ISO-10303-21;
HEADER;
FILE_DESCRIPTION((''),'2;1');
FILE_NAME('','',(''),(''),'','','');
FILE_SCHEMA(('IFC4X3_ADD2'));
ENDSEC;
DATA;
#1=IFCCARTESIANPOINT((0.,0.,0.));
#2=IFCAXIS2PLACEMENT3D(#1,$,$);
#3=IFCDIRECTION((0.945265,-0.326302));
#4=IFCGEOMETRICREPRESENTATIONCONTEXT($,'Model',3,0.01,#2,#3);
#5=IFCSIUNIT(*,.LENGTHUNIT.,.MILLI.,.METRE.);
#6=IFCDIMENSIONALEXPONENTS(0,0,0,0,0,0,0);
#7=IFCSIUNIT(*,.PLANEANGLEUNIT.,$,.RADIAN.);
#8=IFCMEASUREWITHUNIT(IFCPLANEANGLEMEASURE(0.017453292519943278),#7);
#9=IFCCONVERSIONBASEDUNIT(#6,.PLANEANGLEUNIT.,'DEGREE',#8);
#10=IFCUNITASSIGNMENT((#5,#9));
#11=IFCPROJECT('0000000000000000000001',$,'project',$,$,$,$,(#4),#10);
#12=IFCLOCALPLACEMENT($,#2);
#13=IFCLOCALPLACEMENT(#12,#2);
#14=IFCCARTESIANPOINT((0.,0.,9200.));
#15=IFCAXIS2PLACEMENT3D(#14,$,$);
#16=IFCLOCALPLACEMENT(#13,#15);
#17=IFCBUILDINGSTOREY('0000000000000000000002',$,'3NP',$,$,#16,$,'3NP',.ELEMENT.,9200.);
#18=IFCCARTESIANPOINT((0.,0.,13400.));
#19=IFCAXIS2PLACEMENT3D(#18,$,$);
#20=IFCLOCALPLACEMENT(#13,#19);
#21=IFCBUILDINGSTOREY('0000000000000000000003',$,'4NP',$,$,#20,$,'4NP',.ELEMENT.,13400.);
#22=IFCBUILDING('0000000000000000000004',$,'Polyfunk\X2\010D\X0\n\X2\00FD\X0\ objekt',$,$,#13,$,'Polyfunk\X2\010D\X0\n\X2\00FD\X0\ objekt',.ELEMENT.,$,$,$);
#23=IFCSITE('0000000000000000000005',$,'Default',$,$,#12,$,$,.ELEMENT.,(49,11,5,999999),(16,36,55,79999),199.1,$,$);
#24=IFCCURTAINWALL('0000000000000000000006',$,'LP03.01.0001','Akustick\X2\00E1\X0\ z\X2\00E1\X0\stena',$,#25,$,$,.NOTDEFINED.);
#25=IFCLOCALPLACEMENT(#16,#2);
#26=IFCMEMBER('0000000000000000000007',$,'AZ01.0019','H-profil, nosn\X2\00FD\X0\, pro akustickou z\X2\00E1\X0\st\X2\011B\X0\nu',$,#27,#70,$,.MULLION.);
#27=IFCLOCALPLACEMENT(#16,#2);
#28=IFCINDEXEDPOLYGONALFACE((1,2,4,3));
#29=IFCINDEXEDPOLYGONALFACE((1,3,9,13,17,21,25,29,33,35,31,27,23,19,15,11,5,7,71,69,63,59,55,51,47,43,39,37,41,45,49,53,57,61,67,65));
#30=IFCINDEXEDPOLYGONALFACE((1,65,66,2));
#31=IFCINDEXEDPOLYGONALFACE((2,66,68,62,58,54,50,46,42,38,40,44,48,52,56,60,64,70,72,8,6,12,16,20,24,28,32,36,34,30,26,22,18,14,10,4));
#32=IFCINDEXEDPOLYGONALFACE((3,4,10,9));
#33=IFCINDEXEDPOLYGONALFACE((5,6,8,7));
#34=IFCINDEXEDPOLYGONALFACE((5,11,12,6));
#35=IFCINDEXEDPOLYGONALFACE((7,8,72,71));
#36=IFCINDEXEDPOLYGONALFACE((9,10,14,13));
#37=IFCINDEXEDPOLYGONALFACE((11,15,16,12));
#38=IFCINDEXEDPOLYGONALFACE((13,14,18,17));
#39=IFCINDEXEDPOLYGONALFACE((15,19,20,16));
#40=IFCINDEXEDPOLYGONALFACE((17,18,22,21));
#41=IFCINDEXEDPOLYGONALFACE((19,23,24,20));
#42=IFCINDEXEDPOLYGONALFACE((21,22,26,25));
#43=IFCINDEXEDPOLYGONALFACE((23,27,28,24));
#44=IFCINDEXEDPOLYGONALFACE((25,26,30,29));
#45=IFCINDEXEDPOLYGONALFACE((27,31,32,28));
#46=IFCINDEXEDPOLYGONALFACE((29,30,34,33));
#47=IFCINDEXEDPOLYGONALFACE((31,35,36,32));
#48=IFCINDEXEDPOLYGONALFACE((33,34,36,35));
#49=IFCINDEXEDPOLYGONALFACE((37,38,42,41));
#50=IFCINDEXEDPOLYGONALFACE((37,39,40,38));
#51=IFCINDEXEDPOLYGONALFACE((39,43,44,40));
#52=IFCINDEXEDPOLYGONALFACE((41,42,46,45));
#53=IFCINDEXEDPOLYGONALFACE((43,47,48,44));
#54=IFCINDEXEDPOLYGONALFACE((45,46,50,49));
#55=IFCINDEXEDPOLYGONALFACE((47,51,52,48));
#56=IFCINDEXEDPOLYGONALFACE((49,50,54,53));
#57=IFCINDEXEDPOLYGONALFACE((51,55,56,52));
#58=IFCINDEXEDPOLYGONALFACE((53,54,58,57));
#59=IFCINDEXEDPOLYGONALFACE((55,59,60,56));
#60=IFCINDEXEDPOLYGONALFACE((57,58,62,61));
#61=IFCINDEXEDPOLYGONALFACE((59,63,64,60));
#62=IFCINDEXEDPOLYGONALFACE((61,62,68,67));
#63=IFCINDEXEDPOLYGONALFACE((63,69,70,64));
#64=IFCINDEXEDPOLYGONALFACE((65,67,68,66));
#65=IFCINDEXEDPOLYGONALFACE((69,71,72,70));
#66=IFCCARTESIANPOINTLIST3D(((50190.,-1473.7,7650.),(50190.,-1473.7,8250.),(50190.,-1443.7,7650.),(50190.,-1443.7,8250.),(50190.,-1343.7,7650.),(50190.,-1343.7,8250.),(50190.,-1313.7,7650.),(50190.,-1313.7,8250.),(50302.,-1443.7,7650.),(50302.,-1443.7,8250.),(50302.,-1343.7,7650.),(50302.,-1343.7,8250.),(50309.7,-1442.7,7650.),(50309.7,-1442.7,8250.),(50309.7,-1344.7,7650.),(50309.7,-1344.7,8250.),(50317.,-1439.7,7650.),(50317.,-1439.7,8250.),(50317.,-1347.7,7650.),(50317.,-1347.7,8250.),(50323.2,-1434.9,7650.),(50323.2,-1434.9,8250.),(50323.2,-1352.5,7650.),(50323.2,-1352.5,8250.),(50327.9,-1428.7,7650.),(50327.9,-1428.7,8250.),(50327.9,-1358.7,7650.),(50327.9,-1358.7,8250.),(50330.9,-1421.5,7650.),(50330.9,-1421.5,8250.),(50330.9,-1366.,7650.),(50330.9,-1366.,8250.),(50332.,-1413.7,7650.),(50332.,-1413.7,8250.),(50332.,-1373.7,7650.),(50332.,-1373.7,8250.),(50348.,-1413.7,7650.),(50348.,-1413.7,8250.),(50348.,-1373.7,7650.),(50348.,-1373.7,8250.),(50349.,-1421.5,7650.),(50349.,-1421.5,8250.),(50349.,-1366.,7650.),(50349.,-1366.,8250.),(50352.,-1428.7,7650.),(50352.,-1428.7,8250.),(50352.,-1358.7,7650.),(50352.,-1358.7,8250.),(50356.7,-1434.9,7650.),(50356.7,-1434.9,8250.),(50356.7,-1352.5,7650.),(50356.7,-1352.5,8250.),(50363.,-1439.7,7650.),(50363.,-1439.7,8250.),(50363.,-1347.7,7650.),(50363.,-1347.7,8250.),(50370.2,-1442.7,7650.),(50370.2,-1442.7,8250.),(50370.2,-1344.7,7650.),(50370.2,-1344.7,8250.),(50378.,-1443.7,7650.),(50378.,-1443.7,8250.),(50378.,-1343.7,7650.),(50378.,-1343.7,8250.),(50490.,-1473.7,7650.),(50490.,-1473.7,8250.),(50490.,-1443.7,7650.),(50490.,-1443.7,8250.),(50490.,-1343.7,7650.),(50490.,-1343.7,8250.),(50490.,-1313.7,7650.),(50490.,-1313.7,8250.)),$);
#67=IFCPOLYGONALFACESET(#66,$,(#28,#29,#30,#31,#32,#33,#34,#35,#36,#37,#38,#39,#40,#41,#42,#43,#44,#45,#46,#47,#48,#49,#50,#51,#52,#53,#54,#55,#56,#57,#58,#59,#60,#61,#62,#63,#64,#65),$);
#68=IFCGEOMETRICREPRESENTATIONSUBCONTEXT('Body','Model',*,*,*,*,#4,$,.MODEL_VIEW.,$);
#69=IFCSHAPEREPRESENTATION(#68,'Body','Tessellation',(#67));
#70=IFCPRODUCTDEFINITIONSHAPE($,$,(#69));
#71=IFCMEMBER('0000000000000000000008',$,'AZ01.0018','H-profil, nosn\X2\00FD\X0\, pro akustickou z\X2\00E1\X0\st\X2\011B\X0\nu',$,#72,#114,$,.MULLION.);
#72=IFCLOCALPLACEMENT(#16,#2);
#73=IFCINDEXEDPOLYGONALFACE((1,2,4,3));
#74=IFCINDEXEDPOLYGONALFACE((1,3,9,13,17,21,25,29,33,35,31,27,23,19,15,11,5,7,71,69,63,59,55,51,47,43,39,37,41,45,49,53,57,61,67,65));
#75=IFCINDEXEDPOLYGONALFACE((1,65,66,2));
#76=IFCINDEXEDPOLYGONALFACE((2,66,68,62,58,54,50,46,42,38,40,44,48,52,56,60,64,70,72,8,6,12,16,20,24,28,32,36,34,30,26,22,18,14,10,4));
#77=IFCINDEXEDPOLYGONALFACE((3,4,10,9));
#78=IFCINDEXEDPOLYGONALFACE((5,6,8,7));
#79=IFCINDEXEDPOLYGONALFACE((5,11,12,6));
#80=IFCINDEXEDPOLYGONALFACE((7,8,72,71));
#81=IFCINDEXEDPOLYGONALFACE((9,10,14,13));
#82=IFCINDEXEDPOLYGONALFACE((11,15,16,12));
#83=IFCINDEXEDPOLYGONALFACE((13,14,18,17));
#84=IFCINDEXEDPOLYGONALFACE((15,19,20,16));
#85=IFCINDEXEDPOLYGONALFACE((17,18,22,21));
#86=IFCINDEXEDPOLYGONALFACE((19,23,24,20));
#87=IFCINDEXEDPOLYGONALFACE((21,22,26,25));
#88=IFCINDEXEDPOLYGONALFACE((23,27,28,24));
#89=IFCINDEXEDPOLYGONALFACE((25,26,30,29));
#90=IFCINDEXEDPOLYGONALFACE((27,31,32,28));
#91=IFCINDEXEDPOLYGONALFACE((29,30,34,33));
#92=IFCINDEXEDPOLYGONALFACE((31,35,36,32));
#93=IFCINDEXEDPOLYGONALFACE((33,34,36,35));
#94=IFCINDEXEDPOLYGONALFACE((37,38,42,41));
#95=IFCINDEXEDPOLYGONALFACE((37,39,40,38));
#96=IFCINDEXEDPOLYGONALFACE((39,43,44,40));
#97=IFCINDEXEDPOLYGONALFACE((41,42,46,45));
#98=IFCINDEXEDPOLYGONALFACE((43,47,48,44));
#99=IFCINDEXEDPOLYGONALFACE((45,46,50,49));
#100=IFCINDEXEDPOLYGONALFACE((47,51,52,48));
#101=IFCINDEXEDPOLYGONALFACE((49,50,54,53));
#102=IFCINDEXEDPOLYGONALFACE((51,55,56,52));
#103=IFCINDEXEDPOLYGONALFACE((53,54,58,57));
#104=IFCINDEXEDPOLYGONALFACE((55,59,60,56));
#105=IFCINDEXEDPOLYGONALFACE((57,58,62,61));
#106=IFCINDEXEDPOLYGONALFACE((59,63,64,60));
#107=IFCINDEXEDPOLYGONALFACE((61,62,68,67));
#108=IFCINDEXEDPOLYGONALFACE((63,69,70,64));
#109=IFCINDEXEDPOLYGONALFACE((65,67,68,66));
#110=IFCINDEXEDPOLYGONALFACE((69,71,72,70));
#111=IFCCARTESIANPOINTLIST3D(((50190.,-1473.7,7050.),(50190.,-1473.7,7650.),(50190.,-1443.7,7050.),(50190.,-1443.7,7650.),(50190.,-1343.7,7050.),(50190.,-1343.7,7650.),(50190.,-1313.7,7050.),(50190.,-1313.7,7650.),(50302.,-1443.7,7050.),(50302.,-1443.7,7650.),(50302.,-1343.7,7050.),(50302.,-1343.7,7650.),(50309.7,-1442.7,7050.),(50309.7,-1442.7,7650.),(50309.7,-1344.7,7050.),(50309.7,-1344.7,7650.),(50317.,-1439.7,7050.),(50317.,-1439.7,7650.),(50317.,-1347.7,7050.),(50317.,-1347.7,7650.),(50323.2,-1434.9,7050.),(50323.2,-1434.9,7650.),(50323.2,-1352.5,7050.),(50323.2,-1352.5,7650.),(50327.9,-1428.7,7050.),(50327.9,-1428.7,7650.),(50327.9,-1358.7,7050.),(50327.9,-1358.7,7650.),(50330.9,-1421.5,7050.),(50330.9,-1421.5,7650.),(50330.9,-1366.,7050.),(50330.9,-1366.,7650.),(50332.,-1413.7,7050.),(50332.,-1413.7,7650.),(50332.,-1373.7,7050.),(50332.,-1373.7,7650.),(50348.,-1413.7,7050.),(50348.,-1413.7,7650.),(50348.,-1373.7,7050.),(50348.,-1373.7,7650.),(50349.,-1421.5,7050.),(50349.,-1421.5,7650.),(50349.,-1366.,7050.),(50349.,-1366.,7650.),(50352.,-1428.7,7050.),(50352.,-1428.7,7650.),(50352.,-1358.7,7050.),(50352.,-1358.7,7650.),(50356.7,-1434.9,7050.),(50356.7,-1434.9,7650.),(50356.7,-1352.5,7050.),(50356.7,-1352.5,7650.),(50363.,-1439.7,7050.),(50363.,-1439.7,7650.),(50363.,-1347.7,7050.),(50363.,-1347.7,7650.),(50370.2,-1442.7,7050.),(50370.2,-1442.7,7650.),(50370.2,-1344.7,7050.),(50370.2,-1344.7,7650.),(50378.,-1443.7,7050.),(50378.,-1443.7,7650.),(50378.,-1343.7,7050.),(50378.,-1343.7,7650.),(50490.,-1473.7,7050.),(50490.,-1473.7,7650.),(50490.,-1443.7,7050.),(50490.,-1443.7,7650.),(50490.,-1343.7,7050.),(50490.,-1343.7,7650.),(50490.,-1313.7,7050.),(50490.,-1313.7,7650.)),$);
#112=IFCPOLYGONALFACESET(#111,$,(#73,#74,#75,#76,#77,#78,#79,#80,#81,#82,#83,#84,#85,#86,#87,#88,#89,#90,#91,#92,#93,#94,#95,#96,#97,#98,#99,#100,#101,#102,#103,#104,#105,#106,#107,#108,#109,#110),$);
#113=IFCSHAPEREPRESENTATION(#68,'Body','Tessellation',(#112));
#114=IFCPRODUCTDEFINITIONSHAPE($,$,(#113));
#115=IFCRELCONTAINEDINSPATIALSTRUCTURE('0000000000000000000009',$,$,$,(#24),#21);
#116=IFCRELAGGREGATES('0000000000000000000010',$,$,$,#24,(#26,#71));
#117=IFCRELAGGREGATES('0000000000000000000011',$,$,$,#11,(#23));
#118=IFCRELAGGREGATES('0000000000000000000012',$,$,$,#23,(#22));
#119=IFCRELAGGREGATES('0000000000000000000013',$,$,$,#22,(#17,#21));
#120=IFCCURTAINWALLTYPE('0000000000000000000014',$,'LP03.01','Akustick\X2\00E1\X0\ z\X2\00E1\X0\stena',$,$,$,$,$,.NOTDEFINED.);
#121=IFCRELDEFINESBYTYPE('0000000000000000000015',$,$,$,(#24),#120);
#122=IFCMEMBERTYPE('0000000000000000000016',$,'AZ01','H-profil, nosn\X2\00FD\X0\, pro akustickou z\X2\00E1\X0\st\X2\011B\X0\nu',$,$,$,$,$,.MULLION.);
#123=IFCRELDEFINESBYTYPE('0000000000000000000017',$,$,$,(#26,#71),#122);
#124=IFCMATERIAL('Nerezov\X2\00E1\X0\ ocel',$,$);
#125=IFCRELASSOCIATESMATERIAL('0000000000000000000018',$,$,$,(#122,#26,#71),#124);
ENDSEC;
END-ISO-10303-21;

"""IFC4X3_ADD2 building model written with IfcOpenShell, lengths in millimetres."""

from ifc_helpers import new_model, entity, si_unit, converted_unit, direction, frame, frame_2d, origin, place, context, subcontext, project, spatial, polyline, circle_curve, parameter, trimmed, segment, composite_curve, outline, extrude, source, transform, mapped, material, material_profile, profile_set, profile_usage, type_object, element, aggregate, save


model = new_model("IFC4X3_ADD2")

# Units and contexts
model_context = context("Model", 3, precision=0.01, world=origin(), true_north=direction((0.945265, -0.326302)))
body_context = subcontext(model_context, "Body", "Model", "MODEL_VIEW")
ifc_project = project(units=[si_unit("LENGTHUNIT", "METRE", prefix="MILLI"), converted_unit("PLANEANGLEUNIT", "DEGREE", entity("IfcPlaneAngleMeasure", 0.017453292519943278), si_unit("PLANEANGLEUNIT", "RADIAN"), dimensions=[0, 0, 0, 0, 0, 0, 0])], contexts=[model_context])

# Site, building, storey
site_placement = place(None, origin())
site = spatial("IfcSite", under=ifc_project, at=site_placement, Name="Default", CompositionType="ELEMENT", RefLatitude=(49, 11, 5, 999999), RefLongitude=(16, 36, 55, 79999), RefElevation=199.1)
building_placement = place(site_placement, origin())
building = spatial("IfcBuilding", under=site, at=building_placement, Name="Polyfunkčný objekt", LongName="Polyfunkčný objekt", CompositionType="ELEMENT")
storey_1_placement = place(building_placement, frame((0.0, 0.0, 9200.0)))
storey_1 = spatial("IfcBuildingStorey", under=building, at=storey_1_placement, Name="3NP", LongName="3NP", CompositionType="ELEMENT", Elevation=9200.0)

# Shared definitions
storey_2_placement = place(building_placement, frame((0.0, 0.0, 13400.0)))
storey_2 = spatial("IfcBuildingStorey", under=building, at=storey_2_placement, Name="4NP", LongName="4NP", CompositionType="ELEMENT", Elevation=13400.0)

# Curtain wall, members
curtain_wall_type_1 = type_object("IfcCurtainWallType", Name="LP03.01", Description="Akustická zástena", PredefinedType="NOTDEFINED")
curtain_wall_1_placement = place(storey_2_placement, frame((0.0, 0.0, -13400.0)))
curtain_wall_1 = element("IfcCurtainWall", 1, at=curtain_wall_1_placement, inside=storey_2, type_object=curtain_wall_type_1, Name="LP03.01.0001", Description="Akustická zástena", PredefinedType="NOTDEFINED")
ifc_material_1 = material(Name="Nerezová ocel")
ifc_material_profile_1 = material_profile(ifc_material_1, outline(composite_curve([segment(polyline([(50.0, -150.0), (80.0, -150.0)]), True, "CONTINUOUS"), segment(polyline([(80.0, -150.0), (80.0, 150.0)]), True, "CONTINUOUS"), segment(polyline([(80.0, 150.0), (50.0, 150.0)]), True, "CONTINUOUS"), segment(polyline([(50.0, 150.0), (50.0, 38.0)]), True, "CONTINUOUS"), segment(trimmed(circle_curve(frame_2d((20.0, 38.0), x_axis=(0.0, 1.0)), 30.0), [parameter(180.0)], [parameter(270.0)], True, "PARAMETER"), False, "CONTINUOUS"), segment(polyline([(20.0, 8.0), (-20.0, 8.0)]), True, "CONTINUOUS"), segment(trimmed(circle_curve(frame_2d((-20.0, 38.0), x_axis=(0.0, 1.0)), 30.0), [parameter(90.0)], [parameter(180.0)], True, "PARAMETER"), False, "CONTINUOUS"), segment(polyline([(-50.0, 38.0), (-50.0, 150.0)]), True, "CONTINUOUS"), segment(polyline([(-50.0, 150.0), (-80.0, 150.0)]), True, "CONTINUOUS"), segment(polyline([(-80.0, 150.0), (-80.0, -150.0)]), True, "CONTINUOUS"), segment(polyline([(-80.0, -150.0), (-50.0, -150.0)]), True, "CONTINUOUS"), segment(polyline([(-50.0, -150.0), (-50.0, -38.0)]), True, "CONTINUOUS"), segment(trimmed(circle_curve(frame_2d((-20.0, -38.0), x_axis=(0.0, 1.0)), 30.0), [parameter(0.0)], [parameter(90.0)], True, "PARAMETER"), False, "CONTINUOUS"), segment(polyline([(-20.0, -8.0), (20.0, -8.0)]), True, "CONTINUOUS"), segment(trimmed(circle_curve(frame_2d((20.0, -38.0), x_axis=(0.0, 1.0)), 30.0), [parameter(270.0)], [parameter(0.0)], True, "PARAMETER"), False, "CONTINUOUS"), segment(polyline([(50.0, -38.0), (50.0, -150.0)]), True, "CONTINUOUS")], self_intersect=False)), Name="Profil zástena")
ifc_profile_set_1 = profile_set([ifc_material_profile_1], Name="Profil zástena")
ifc_profile_usage_1 = profile_usage(ifc_profile_set_1)
member_type_1 = type_object("IfcMemberType", Name="AZ01", Description="H-profil, nosný, pro akustickou zástěnu", PredefinedType="MULLION", material=ifc_profile_set_1)
shared_shape_1 = source(origin(), body_context, "Body", "SweptSolid", [
    extrude(outline(composite_curve([segment(polyline([(-150.0, -50.0), (-150.0, -80.0)]), True, "CONTINUOUS"), segment(polyline([(-150.0, -80.0), (150.0, -80.0)]), True, "CONTINUOUS"), segment(polyline([(150.0, -80.0), (150.0, -50.0)]), True, "CONTINUOUS"), segment(polyline([(150.0, -50.0), (38.0, -50.0)]), True, "CONTINUOUS"), segment(trimmed(circle_curve(frame_2d((38.0, -20.0), x_axis=(1.0, 0.0)), 30.0), [parameter(180.0)], [parameter(270.0)], True, "PARAMETER"), False, "CONTINUOUS"), segment(polyline([(8.0, -20.0), (8.0, 20.0)]), True, "CONTINUOUS"), segment(trimmed(circle_curve(frame_2d((38.0, 20.0), x_axis=(1.0, 0.0)), 30.0), [parameter(90.0)], [parameter(180.0)], True, "PARAMETER"), False, "CONTINUOUS"), segment(polyline([(38.0, 50.0), (150.0, 50.0)]), True, "CONTINUOUS"), segment(polyline([(150.0, 50.0), (150.0, 80.0)]), True, "CONTINUOUS"), segment(polyline([(150.0, 80.0), (-150.0, 80.0)]), True, "CONTINUOUS"), segment(polyline([(-150.0, 80.0), (-150.0, 50.0)]), True, "CONTINUOUS"), segment(polyline([(-150.0, 50.0), (-38.0, 50.0)]), True, "CONTINUOUS"), segment(trimmed(circle_curve(frame_2d((-38.0, 20.0), x_axis=(1.0, 0.0)), 30.0), [parameter(0.0)], [parameter(90.0)], True, "PARAMETER"), False, "CONTINUOUS"), segment(polyline([(-8.0, 20.0), (-8.0, -20.0)]), True, "CONTINUOUS"), segment(trimmed(circle_curve(frame_2d((-38.0, -20.0), x_axis=(1.0, 0.0)), 30.0), [parameter(270.0)], [parameter(0.0)], True, "PARAMETER"), False, "CONTINUOUS"), segment(polyline([(-38.0, -50.0), (-150.0, -50.0)]), True, "CONTINUOUS")], self_intersect=False)), frame((-150.0, 0.0, -600.0), z_axis=(0.0, 0.0, -1.0), x_axis=(-1.0, 0.0, 0.0)), (0.0, 0.0, -1.0), 600.0),
])
member_1_placement = place(curtain_wall_1_placement, frame((50190.0, -1393.7, 17450.0), z_axis=(0.0, 0.0, 1.0), x_axis=(-1.0, 0.0, 0.0)))
member_1 = element("IfcMember", 2, at=member_1_placement, type_object=member_type_1, material=ifc_profile_usage_1, Name="AZ01.0019", Description="H-profil, nosný, pro akustickou zástěnu", PredefinedType="MULLION", context=body_context, shape_type="MappedRepresentation", body=[
    mapped(shared_shape_1, transform((0.0, 0.0, 0.0), scale=1.0)),
])
member_2_placement = place(curtain_wall_1_placement, frame((50190.0, -1393.7, 16850.0), z_axis=(0.0, 0.0, 1.0), x_axis=(-1.0, 0.0, 0.0)))
member_2 = element("IfcMember", 3, at=member_2_placement, type_object=member_type_1, material=ifc_profile_usage_1, Name="AZ01.0018", Description="H-profil, nosný, pro akustickou zástěnu", PredefinedType="MULLION", context=body_context, shape_type="MappedRepresentation", body=[
    mapped(shared_shape_1, transform((0.0, 0.0, 0.0), scale=1.0)),
])

aggregate(curtain_wall_1, [member_1, member_2])

save(model, "model.ifc")
